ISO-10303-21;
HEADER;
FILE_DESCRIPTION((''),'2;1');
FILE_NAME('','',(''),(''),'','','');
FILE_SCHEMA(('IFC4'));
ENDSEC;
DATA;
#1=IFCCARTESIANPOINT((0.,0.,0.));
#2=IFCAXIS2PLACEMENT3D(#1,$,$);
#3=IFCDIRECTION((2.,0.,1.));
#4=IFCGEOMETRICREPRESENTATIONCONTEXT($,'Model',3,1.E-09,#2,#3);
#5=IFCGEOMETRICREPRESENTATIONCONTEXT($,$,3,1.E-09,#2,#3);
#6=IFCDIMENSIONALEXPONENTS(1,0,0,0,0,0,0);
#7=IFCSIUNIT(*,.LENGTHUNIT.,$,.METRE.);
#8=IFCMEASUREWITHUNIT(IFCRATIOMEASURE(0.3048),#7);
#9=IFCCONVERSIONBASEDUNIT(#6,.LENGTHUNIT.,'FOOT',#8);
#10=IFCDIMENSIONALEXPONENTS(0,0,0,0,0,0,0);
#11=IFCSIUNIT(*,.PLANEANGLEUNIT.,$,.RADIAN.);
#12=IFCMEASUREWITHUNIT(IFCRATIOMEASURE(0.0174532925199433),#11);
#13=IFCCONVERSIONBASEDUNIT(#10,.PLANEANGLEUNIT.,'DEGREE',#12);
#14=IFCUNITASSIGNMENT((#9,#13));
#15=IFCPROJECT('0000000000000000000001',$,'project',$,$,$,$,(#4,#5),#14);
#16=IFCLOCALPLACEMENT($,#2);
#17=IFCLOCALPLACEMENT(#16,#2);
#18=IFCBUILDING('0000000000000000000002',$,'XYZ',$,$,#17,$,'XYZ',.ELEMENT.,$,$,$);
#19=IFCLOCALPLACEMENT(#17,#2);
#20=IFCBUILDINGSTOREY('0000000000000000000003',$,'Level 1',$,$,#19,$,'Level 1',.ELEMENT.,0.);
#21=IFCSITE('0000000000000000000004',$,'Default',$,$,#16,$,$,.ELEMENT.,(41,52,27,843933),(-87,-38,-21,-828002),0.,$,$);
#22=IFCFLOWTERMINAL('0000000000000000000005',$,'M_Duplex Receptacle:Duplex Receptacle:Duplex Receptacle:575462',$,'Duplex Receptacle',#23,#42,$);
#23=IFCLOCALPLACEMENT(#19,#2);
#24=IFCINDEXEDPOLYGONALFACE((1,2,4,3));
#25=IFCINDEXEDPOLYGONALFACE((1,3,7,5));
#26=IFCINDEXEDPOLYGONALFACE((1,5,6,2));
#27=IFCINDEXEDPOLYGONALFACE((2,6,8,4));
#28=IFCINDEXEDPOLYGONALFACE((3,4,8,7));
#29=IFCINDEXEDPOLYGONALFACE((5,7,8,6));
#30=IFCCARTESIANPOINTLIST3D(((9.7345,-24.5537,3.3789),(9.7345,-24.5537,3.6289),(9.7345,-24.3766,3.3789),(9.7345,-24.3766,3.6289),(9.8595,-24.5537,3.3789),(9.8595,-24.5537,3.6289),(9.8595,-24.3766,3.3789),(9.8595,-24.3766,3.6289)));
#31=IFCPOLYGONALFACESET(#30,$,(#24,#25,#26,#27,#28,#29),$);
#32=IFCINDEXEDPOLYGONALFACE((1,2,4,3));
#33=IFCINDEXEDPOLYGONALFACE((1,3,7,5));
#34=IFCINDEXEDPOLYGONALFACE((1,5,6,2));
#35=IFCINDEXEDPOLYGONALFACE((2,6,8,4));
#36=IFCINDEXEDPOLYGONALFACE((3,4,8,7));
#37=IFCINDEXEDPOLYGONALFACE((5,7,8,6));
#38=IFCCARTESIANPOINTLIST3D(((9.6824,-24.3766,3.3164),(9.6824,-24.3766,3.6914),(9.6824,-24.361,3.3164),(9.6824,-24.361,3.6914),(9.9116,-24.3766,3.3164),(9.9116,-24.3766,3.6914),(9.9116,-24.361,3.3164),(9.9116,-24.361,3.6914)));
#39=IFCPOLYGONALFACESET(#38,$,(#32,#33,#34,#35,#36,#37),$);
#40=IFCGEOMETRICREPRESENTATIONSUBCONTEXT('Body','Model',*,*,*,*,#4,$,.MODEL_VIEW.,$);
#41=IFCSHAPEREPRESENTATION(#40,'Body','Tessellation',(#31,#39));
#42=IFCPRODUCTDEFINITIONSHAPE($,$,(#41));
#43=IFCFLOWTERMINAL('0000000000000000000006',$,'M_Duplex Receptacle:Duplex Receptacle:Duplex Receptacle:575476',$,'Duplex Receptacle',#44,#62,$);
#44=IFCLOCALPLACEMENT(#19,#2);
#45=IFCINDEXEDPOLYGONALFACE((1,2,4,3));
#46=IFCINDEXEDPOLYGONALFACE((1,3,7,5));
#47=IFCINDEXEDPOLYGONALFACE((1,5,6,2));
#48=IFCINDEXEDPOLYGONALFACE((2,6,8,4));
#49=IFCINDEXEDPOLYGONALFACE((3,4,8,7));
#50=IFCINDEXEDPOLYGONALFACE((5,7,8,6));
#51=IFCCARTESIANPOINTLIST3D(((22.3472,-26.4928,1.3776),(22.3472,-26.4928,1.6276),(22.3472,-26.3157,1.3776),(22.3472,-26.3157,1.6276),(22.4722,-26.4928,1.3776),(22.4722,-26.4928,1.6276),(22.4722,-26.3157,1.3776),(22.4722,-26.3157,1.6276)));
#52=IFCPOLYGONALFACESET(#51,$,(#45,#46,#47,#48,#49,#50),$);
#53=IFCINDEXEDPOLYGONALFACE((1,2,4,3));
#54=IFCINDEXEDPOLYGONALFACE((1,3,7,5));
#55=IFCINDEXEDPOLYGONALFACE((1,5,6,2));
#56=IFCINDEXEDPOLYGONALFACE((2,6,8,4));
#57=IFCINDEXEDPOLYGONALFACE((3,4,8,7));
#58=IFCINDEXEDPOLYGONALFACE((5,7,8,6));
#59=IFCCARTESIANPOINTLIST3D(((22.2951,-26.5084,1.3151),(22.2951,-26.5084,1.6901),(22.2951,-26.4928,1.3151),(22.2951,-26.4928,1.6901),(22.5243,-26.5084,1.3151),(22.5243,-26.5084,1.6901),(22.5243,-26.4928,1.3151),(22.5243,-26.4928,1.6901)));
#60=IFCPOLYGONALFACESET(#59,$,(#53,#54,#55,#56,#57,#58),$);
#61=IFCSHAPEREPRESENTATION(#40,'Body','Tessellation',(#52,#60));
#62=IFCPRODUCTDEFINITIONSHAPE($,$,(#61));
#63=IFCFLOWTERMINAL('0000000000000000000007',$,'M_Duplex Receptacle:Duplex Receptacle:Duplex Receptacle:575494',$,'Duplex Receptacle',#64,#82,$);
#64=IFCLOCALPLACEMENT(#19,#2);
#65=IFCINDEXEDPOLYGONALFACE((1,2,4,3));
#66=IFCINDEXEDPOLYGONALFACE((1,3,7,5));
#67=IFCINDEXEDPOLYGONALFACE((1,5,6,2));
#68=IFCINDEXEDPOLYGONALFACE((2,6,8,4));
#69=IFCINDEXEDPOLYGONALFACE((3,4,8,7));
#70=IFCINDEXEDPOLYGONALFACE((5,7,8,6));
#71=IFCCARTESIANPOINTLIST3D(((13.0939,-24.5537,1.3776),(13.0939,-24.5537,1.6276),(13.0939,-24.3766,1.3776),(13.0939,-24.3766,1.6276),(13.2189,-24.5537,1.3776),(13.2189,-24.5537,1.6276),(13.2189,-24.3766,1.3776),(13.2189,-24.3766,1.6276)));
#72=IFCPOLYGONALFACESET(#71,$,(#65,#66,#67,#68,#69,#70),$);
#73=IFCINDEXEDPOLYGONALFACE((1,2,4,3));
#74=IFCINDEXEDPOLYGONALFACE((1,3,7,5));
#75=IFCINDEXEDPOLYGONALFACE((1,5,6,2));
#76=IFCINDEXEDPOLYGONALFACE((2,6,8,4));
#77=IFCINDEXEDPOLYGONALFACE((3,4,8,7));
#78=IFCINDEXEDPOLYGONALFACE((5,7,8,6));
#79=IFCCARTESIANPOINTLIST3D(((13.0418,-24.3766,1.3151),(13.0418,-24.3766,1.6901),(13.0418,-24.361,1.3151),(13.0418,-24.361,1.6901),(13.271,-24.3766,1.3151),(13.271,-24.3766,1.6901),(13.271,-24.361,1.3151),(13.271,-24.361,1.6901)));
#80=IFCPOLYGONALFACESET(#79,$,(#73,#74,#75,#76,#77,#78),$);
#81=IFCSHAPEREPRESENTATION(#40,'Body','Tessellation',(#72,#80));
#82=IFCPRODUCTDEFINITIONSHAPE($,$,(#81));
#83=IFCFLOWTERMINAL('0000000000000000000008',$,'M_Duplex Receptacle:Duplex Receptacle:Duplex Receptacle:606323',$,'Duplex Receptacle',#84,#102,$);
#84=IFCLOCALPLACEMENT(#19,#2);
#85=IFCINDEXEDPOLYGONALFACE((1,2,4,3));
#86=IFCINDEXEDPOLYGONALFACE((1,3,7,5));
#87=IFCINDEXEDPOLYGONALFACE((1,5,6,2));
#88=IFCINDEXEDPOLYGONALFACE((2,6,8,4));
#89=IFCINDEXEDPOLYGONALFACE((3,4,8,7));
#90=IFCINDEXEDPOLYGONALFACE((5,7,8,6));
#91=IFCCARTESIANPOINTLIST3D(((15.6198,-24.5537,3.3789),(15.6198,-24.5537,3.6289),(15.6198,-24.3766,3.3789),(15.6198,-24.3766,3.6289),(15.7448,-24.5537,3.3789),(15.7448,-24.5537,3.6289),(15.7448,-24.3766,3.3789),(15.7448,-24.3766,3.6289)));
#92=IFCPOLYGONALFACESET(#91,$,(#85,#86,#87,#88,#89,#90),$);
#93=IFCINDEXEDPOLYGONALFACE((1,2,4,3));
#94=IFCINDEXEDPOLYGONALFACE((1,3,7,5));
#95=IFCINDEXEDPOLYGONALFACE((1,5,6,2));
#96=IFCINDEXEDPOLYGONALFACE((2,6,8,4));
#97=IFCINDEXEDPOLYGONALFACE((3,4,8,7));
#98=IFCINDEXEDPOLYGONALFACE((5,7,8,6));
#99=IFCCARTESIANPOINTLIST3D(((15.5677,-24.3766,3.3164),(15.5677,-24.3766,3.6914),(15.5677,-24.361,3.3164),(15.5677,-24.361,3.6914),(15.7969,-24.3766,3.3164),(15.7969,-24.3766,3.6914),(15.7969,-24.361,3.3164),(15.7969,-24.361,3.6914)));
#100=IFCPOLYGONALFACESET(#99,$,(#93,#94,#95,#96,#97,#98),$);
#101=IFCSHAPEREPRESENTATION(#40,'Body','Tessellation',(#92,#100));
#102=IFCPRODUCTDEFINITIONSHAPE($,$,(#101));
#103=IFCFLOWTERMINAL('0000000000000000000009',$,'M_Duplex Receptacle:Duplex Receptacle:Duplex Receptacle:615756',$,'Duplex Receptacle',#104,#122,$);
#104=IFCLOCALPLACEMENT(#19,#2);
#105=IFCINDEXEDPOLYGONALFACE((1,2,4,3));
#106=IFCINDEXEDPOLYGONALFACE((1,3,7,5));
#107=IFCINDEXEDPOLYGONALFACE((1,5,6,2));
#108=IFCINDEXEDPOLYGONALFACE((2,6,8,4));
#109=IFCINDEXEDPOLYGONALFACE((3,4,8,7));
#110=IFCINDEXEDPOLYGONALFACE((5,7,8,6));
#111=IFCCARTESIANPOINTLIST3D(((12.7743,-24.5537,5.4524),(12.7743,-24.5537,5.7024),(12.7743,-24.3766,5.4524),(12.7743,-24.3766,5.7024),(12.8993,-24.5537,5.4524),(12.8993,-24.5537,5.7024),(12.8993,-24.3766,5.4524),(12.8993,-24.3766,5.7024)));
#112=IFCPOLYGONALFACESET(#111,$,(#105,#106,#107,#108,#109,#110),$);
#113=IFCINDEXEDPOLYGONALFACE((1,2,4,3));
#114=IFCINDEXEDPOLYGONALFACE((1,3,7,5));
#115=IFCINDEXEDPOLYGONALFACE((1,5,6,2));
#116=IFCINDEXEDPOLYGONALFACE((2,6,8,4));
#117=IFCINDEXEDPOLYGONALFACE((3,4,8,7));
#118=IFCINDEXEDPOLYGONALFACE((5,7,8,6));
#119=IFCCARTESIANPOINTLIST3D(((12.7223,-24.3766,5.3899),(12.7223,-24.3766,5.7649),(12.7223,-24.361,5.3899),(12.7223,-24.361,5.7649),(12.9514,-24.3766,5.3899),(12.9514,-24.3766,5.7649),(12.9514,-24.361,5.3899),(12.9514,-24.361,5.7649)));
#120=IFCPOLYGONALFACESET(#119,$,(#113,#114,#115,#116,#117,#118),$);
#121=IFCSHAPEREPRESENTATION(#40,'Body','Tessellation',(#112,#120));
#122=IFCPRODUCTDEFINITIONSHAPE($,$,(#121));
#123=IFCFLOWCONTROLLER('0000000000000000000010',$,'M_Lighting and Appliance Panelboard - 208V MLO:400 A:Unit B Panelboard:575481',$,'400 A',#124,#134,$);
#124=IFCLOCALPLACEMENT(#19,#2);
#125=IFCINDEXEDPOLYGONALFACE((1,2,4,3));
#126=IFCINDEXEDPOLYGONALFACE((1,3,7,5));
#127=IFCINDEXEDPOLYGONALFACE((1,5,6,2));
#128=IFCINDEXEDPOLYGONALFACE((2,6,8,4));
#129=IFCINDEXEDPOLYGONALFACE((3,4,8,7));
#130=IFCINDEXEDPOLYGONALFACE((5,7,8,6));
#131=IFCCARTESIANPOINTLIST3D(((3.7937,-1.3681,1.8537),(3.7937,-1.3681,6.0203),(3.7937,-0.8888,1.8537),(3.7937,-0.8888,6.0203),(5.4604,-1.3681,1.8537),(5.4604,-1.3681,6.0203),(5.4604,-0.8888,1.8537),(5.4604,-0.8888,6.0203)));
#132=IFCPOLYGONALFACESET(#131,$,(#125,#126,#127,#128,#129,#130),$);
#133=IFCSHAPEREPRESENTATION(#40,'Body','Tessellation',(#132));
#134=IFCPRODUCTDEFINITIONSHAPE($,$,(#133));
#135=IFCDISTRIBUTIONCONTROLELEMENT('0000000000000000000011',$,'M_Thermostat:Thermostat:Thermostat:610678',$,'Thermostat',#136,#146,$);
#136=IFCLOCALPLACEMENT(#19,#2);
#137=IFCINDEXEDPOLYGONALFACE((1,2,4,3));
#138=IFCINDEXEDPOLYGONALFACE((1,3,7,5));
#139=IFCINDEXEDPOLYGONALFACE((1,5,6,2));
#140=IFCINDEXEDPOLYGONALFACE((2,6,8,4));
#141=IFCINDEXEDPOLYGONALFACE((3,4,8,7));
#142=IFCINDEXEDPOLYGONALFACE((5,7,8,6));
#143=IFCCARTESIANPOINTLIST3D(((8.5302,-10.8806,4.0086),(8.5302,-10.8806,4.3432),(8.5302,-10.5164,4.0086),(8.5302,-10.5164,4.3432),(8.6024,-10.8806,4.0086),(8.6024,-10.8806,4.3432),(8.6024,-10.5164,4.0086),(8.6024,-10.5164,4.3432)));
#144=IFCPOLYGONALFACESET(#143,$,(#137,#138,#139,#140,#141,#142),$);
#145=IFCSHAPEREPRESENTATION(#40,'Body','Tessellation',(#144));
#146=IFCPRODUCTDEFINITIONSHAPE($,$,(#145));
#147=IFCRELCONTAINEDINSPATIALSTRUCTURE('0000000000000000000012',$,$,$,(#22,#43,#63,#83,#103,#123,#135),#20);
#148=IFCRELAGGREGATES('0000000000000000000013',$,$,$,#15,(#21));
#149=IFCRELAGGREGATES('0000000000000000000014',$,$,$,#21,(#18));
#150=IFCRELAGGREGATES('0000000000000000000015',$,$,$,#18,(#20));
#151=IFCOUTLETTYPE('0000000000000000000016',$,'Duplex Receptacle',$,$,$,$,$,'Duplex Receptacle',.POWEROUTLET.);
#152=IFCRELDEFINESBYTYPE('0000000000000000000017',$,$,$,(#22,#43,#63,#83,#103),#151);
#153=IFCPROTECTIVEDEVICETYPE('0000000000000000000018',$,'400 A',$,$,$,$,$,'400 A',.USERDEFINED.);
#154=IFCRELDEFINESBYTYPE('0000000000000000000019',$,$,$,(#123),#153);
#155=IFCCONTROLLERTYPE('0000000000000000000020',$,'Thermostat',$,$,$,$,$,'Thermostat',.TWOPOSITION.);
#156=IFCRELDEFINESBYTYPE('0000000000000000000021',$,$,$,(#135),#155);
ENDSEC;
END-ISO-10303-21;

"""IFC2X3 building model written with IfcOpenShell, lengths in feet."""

from ifc_helpers import new_model, entity, si_unit, converted_unit, direction, frame, frame_2d, origin, origin_2d_with_axis, place, context, subcontext, project, spatial, rectangle, extrude, source, transform, mapped, type_object, type_shapes, element, save


model = new_model("IFC2X3")

# Units and contexts
model_context = context("Model", 3, precision=1e-09, world=origin(), true_north=direction((2.0, 0.0, 1.0)))
context_of_model = context(None, 3, precision=1e-09, world=origin(), true_north=direction((2.0, 0.0, 1.0)))
body_context = subcontext(model_context, "Body", "Model", "MODEL_VIEW")
ifc_project = project(units=[converted_unit("LENGTHUNIT", "FOOT", entity("IfcRatioMeasure", 0.3048), si_unit("LENGTHUNIT", "METRE"), dimensions=[1, 0, 0, 0, 0, 0, 0]), converted_unit("PLANEANGLEUNIT", "DEGREE", entity("IfcRatioMeasure", 0.0174532925199433), si_unit("PLANEANGLEUNIT", "RADIAN"), dimensions=[0, 0, 0, 0, 0, 0, 0])], contexts=[model_context, context_of_model])

# Site, building, storey
site_placement = place(None, origin())
site = spatial("IfcSite", under=ifc_project, at=site_placement, Name="Default", CompositionType="ELEMENT", RefLatitude=(41, 52, 27, 843933), RefLongitude=(-87, -38, -21, -828002), RefElevation=0.0)
building_placement = place(site_placement, origin())
building = spatial("IfcBuilding", under=site, at=building_placement, Name="XYZ", LongName="XYZ", CompositionType="ELEMENT")
storey_placement = place(building_placement, origin())
storey = spatial("IfcBuildingStorey", under=building, at=storey_placement, Name="Level 1", LongName="Level 1", CompositionType="ELEMENT", Elevation=0.0)

# Flow terminals
outlet_type = type_object("IfcOutletType", Name="Duplex Receptacle", ElementType="Duplex Receptacle", PredefinedType="POWEROUTLET")
shared_shape_1 = source(origin(), body_context, "Body", "SweptSolid", [
    extrude(rectangle(XDim=0.125, YDim=0.25, at=origin_2d_with_axis()), frame((0.0, 0.0, -0.1771), z_axis=(0.0, 0.0, 1.0), x_axis=(-1.0, 0.0, 0.0)), (0.0, 0.0, 1.0), 0.1771),
    extrude(rectangle(XDim=0.2292, YDim=0.375, at=frame_2d((0.0, 0.0), x_axis=(1.0, 0.0))), frame((0.0, 0.0, 0.0), z_axis=(0.0, 0.0, 1.0), x_axis=(-1.0, 0.0, 0.0)), (0.0, 0.0, 1.0), 0.0156),
])
type_shapes(outlet_type, [shared_shape_1])
for number, where, z_axis, x_axis, name in (
    (1, (9.797, -24.3766, 3.5039), (0.0, 1.0, 0.0), (-1.0, 0.0, 0.0), "M_Duplex Receptacle:Duplex Receptacle:Duplex Receptacle:575462"),
    (2, (22.4097, -26.4928, 1.5026), (0.0, -1.0, 0.0), (1.0, 0.0, 0.0), "M_Duplex Receptacle:Duplex Receptacle:Duplex Receptacle:575476"),
    (3, (13.1564, -24.3766, 1.5026), (0.0, 1.0, 0.0), (-1.0, 0.0, 0.0), "M_Duplex Receptacle:Duplex Receptacle:Duplex Receptacle:575494"),
    (4, (15.6823, -24.3766, 3.5039), (0.0, 1.0, 0.0), (-1.0, 0.0, 0.0), "M_Duplex Receptacle:Duplex Receptacle:Duplex Receptacle:606323"),
    (5, (12.8368, -24.3766, 5.5774), (0.0, 1.0, 0.0), (-1.0, 0.0, 0.0), "M_Duplex Receptacle:Duplex Receptacle:Duplex Receptacle:615756"),
):
    element("IfcFlowTerminal", number, at=place(storey_placement, frame(where, z_axis=z_axis, x_axis=x_axis)), inside=storey, type_object=outlet_type, Name=name, ObjectType="Duplex Receptacle", context=body_context, shape_type="MappedRepresentation", body=[
        mapped(shared_shape_1, transform((0.0, 0.0, 0.0), scale=1.0)),
    ])

# Flow controller
protective_device_type = type_object("IfcProtectiveDeviceType", Name="400 A", ElementType="400 A", PredefinedType="USERDEFINED")
shared_shape_2 = source(origin(), body_context, "Body", "SweptSolid", [
    extrude(rectangle(XDim=1.6667, YDim=4.1667, at=origin_2d_with_axis()), frame((0.0, -1.375, -0.4793), z_axis=(0.0, 0.0, 1.0), x_axis=(-1.0, 0.0, 0.0)), (0.0, 0.0, 1.0), 0.4793),
])
type_shapes(protective_device_type, [shared_shape_2])
flow_controller_placement = place(storey_placement, frame((4.627, -1.3681, 5.312), z_axis=(0.0, -1.0, 0.0), x_axis=(1.0, 0.0, 0.0)))
element("IfcFlowController", 6, at=flow_controller_placement, inside=storey, type_object=protective_device_type, Name="M_Lighting and Appliance Panelboard - 208V MLO:400 A:Unit B Panelboard:575481", ObjectType="400 A", context=body_context, shape_type="MappedRepresentation", body=[
    mapped(shared_shape_2, transform((0.0, 0.0, 0.0), scale=1.0)),
])

# Distribution control element
controller_type = type_object("IfcControllerType", Name="Thermostat", ElementType="Thermostat", PredefinedType="TWOPOSITION")
shared_shape_3 = source(origin(), body_context, "Body", "SweptSolid", [
    extrude(rectangle(XDim=0.3346, YDim=0.3642, at=origin_2d_with_axis()), frame((0.0, -0.1673, 0.0), z_axis=(0.0, 0.0, 1.0), x_axis=(0.0, 1.0, 0.0)), (0.0, 0.0, 1.0), 0.0722),
])
type_shapes(controller_type, [shared_shape_3])
distribution_control_element_placement = place(storey_placement, frame((8.5302, -10.6985, 4.3432), z_axis=(1.0, 0.0, 0.0), x_axis=(0.0, 1.0, 0.0)))
element("IfcDistributionControlElement", 7, at=distribution_control_element_placement, inside=storey, type_object=controller_type, Name="M_Thermostat:Thermostat:Thermostat:610678", ObjectType="Thermostat", context=body_context, shape_type="MappedRepresentation", body=[
    mapped(shared_shape_3, transform((0.0, 0.0, 0.0), scale=1.0)),
])

save(model, "model.ifc")
